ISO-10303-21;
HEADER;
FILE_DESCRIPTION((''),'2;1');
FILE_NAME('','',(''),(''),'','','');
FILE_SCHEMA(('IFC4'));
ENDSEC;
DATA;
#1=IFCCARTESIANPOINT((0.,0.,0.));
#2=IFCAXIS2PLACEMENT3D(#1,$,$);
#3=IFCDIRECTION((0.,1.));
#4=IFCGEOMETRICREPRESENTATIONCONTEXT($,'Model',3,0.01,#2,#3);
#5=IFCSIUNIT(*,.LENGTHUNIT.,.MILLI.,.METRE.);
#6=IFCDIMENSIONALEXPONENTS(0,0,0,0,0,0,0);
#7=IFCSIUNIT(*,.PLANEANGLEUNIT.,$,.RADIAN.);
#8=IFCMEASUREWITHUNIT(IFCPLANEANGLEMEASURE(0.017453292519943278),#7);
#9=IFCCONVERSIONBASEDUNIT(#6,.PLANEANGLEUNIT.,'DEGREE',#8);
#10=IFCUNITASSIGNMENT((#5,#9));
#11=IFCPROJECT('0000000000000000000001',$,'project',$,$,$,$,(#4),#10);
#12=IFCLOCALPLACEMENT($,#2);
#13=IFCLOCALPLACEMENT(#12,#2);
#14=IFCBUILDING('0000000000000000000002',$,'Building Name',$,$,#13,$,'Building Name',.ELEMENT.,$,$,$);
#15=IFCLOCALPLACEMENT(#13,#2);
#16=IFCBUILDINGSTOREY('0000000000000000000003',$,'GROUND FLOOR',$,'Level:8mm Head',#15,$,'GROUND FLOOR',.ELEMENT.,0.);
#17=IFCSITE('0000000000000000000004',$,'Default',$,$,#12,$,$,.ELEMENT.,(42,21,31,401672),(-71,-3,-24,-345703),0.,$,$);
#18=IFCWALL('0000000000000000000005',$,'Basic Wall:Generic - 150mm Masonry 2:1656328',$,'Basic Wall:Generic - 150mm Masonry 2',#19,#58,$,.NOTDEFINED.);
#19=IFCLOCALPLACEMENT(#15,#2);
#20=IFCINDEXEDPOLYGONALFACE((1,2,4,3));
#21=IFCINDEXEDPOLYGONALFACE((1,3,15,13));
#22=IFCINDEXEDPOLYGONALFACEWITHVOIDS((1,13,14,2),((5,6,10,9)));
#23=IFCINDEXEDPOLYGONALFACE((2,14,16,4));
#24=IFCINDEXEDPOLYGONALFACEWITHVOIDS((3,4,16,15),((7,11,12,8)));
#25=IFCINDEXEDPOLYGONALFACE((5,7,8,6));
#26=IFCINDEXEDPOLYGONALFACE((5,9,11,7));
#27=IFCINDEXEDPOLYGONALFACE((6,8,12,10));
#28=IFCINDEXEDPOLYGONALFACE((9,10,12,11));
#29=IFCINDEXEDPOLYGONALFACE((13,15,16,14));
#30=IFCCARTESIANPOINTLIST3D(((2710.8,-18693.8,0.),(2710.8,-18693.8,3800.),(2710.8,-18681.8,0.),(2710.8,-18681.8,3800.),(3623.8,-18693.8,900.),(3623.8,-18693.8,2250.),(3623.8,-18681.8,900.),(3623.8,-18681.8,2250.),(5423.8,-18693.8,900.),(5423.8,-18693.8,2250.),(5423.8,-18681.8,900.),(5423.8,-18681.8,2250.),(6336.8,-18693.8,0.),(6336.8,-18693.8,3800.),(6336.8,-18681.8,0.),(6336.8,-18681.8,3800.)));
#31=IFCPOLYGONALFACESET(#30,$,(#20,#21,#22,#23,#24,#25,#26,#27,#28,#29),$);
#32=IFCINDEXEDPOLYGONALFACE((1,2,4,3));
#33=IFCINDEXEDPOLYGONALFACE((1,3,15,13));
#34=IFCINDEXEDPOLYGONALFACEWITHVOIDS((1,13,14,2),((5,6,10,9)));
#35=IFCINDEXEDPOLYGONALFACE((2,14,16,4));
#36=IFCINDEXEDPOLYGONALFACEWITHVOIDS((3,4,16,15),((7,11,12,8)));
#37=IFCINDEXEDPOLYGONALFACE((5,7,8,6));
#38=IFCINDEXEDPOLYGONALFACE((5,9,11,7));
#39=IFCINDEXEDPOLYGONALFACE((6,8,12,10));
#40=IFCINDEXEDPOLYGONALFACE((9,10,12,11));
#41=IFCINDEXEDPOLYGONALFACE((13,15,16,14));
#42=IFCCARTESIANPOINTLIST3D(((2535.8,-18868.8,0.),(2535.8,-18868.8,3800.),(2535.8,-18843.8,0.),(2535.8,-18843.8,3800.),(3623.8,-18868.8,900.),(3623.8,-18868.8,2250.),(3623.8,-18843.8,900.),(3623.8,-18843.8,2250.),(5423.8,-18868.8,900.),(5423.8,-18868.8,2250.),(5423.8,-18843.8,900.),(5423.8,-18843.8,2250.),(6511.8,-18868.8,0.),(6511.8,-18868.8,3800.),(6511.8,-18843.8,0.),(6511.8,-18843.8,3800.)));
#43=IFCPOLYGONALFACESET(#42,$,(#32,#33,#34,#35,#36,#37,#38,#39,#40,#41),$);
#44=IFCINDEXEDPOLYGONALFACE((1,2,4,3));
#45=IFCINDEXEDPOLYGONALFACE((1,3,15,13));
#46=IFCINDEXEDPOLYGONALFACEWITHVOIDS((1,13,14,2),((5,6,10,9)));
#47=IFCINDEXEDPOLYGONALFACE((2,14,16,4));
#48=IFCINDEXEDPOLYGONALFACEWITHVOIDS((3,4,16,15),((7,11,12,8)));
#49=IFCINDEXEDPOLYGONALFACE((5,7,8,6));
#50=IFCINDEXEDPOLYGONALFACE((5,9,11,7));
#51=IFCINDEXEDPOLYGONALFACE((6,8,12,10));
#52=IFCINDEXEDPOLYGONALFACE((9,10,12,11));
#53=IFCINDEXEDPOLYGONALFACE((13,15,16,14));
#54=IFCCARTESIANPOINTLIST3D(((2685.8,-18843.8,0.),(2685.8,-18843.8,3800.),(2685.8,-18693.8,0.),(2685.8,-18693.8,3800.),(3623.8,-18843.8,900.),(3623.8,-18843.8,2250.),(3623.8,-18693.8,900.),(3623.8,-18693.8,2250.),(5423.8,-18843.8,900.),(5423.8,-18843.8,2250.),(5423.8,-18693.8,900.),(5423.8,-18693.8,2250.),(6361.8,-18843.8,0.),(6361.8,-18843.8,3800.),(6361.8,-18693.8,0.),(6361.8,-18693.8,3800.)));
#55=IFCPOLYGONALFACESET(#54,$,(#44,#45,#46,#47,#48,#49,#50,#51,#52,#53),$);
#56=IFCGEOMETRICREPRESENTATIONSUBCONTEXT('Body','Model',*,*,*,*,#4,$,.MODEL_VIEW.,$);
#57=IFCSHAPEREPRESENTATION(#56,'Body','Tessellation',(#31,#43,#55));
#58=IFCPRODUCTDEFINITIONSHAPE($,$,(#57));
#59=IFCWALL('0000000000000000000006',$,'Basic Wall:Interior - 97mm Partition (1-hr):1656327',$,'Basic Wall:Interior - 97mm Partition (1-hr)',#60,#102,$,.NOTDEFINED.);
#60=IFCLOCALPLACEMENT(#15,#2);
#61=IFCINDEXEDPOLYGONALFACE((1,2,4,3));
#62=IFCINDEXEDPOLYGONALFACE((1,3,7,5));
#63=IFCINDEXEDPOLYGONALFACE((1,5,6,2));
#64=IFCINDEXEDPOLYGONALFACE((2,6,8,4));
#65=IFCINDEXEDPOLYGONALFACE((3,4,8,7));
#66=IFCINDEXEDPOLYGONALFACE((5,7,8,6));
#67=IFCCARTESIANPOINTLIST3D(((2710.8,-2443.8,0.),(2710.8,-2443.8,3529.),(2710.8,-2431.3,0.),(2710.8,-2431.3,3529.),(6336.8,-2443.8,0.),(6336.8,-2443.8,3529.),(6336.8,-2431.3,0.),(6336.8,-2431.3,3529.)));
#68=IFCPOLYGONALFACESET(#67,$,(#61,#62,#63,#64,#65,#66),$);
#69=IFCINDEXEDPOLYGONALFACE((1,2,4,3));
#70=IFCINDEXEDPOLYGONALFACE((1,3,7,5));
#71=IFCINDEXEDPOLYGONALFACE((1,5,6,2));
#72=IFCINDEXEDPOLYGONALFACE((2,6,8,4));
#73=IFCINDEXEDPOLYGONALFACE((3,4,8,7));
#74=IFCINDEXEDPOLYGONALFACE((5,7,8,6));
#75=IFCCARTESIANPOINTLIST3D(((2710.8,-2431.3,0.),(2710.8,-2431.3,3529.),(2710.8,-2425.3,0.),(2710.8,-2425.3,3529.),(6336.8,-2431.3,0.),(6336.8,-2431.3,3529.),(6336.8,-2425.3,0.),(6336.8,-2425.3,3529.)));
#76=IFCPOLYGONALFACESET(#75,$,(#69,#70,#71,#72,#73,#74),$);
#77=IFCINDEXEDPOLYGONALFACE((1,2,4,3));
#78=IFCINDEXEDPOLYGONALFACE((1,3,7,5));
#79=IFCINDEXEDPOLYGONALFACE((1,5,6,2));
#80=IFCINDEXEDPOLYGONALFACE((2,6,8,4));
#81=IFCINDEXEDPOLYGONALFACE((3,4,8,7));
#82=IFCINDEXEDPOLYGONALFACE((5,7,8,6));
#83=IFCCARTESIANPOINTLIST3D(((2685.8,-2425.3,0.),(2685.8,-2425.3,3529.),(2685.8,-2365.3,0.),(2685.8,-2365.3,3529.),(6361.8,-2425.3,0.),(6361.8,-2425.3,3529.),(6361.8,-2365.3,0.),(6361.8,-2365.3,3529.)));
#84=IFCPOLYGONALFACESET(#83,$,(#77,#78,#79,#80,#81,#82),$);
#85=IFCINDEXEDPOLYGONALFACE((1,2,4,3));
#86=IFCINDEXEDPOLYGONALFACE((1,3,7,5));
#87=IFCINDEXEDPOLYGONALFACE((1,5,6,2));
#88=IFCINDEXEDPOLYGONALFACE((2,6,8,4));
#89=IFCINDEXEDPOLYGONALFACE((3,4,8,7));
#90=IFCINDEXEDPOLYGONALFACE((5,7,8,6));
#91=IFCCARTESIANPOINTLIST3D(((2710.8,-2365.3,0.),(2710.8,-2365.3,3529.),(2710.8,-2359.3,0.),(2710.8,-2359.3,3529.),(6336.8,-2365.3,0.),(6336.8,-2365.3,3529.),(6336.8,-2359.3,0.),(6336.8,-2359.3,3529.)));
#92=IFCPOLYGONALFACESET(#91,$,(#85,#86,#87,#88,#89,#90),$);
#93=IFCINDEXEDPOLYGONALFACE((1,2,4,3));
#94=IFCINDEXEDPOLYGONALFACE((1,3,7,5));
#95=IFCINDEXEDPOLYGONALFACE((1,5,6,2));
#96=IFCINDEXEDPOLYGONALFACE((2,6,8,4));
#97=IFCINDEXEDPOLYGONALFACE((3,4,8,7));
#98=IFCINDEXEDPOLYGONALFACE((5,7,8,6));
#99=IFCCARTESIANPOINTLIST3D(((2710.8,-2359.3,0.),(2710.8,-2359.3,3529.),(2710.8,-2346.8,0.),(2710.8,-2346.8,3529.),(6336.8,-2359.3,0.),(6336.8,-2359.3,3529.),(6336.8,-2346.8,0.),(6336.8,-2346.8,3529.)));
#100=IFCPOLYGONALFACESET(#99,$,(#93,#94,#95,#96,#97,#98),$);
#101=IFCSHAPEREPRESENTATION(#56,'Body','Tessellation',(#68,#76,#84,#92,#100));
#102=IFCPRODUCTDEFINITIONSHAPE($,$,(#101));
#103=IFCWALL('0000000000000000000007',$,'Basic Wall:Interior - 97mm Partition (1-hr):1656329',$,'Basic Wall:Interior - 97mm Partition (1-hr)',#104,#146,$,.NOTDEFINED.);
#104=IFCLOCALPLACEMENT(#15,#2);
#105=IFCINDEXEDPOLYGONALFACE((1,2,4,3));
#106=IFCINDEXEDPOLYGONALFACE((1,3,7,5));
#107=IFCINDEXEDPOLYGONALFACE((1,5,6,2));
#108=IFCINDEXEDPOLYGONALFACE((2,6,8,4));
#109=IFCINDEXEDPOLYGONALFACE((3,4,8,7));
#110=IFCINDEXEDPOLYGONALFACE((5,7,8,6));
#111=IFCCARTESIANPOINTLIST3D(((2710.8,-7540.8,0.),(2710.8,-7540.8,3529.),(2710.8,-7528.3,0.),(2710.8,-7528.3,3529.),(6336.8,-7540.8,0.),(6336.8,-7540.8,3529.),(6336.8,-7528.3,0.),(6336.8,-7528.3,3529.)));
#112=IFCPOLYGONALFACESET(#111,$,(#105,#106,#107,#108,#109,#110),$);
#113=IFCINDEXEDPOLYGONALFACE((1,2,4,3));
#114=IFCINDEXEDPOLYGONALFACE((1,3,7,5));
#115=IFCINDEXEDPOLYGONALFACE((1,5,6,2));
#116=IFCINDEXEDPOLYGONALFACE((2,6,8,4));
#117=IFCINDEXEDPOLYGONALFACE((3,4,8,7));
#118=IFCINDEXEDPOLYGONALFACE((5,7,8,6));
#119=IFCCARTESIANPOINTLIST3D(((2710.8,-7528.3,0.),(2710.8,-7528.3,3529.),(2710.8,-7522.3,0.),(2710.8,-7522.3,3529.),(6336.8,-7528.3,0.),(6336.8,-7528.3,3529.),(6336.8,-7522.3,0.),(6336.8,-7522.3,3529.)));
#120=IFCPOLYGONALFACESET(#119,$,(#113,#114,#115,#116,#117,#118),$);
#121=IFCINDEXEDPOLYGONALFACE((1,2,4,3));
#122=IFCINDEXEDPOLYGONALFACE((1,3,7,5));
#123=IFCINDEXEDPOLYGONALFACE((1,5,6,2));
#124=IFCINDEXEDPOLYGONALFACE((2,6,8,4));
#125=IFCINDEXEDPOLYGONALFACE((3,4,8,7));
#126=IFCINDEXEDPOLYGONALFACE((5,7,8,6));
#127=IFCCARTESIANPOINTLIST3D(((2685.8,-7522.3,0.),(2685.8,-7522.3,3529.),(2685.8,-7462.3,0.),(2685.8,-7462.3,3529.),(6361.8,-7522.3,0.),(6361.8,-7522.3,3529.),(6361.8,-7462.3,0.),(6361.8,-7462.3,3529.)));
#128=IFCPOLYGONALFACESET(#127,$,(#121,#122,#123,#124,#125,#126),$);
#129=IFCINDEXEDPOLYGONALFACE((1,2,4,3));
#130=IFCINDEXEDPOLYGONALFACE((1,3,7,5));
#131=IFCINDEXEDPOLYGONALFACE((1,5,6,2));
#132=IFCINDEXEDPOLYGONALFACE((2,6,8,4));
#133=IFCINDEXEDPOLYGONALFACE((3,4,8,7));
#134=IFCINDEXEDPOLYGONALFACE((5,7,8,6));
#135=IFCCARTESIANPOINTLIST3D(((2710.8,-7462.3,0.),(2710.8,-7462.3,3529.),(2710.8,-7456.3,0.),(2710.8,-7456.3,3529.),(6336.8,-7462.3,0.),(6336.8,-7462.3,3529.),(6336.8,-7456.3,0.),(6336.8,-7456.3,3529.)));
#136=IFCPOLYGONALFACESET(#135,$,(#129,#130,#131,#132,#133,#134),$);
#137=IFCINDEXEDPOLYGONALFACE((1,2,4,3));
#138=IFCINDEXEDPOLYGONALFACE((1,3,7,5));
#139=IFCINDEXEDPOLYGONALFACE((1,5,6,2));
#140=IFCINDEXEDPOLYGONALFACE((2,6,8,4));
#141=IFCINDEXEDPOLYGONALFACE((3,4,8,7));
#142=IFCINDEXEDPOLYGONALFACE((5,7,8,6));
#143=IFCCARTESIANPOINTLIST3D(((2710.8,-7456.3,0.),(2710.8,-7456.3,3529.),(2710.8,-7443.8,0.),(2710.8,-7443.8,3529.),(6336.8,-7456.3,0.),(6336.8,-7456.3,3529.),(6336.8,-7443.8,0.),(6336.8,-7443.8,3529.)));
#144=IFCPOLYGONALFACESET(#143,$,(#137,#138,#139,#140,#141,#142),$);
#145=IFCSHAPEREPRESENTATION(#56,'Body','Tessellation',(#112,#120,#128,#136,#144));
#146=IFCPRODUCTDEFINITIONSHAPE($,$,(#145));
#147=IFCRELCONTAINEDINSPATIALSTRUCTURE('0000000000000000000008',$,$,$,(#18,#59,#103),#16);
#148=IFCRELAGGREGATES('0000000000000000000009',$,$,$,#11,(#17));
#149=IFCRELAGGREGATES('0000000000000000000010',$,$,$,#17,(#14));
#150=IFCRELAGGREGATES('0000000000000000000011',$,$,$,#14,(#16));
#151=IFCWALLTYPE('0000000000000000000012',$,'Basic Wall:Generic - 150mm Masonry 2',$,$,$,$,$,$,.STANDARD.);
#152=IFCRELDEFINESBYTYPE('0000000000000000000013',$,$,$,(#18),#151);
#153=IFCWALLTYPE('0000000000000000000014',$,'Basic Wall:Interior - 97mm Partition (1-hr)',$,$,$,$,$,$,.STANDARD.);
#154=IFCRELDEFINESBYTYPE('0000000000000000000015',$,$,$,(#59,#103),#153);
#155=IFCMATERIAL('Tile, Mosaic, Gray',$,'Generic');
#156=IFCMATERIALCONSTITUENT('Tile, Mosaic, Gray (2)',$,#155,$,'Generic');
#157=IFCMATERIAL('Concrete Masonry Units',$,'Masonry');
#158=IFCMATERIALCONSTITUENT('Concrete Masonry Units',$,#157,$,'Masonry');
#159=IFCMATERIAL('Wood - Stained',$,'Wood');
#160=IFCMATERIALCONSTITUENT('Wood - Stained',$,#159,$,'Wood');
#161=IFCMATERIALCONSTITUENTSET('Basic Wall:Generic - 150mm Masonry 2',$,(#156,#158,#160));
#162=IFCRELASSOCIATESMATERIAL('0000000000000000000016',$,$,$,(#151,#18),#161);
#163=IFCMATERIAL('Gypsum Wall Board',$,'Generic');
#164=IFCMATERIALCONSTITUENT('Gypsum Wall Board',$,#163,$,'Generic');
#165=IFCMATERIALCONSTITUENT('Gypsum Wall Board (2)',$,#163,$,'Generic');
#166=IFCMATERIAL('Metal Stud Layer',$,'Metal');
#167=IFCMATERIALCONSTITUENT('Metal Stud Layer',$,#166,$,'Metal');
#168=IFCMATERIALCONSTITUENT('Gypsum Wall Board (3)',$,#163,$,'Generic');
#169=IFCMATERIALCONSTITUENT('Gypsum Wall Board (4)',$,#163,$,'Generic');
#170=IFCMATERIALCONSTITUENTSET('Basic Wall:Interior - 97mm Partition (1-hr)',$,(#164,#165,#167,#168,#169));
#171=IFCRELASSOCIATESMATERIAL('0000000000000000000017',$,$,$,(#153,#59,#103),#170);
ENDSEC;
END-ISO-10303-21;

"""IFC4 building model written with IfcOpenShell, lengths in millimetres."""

from ifc_helpers import new_model, entity, si_unit, converted_unit, direction, frame, origin, place, context, subcontext, project, spatial, indexed_curve, outline, extrude, material, constituent, constituent_set, type_object, element, save


model = new_model("IFC4")

# Units and contexts
model_context = context("Model", 3, precision=0.01, world=origin(), true_north=direction((0.0, 1.0)))
body_context = subcontext(model_context, "Body", "Model", "MODEL_VIEW")
ifc_project = project(units=[si_unit("LENGTHUNIT", "METRE", prefix="MILLI"), converted_unit("PLANEANGLEUNIT", "DEGREE", entity("IfcPlaneAngleMeasure", 0.017453292519943278), si_unit("PLANEANGLEUNIT", "RADIAN"), dimensions=[0, 0, 0, 0, 0, 0, 0])], contexts=[model_context])

# Site, building, storey
site_placement = place(None, origin())
site = spatial("IfcSite", under=ifc_project, at=site_placement, Name="Default", CompositionType="ELEMENT", RefLatitude=(42, 21, 31, 401672), RefLongitude=(-71, -3, -24, -345703), RefElevation=0.0)
building_placement = place(site_placement, origin())
building = spatial("IfcBuilding", under=site, at=building_placement, Name="Building Name", LongName="Building Name", CompositionType="ELEMENT")
storey_placement = place(building_placement, origin())
storey = spatial("IfcBuildingStorey", under=building, at=storey_placement, Name="GROUND FLOOR", ObjectType="Level:8mm Head", LongName="GROUND FLOOR", CompositionType="ELEMENT", Elevation=0.0)

# Shared definitions
ifc_material_1 = material(Name="Tile, Mosaic, Gray", Category="Generic")
ifc_constituent_1 = constituent(ifc_material_1, Name="Tile, Mosaic, Gray (2)", Category="Generic")
ifc_material_2 = material(Name="Concrete Masonry Units", Category="Masonry")
ifc_constituent_2 = constituent(ifc_material_2, Name="Concrete Masonry Units", Category="Masonry")
ifc_material_3 = material(Name="Wood - Stained", Category="Wood")
ifc_constituent_3 = constituent(ifc_material_3, Name="Wood - Stained", Category="Wood")
ifc_constituent_set_1 = constituent_set(constituents=[ifc_constituent_1, ifc_constituent_2, ifc_constituent_3], Name="Basic Wall:Generic - 150mm Masonry 2")
wall_type_1 = type_object("IfcWallType", Name="Basic Wall:Generic - 150mm Masonry 2", PredefinedType="STANDARD", material=ifc_constituent_set_1)

# Wall, opening
wall_1_placement = place(storey_placement, frame((2710.8, -18775.3, 0.0)))
wall_1 = element("IfcWall", 1, at=wall_1_placement, inside=storey, type_object=wall_type_1, material=ifc_constituent_set_1, Name="Basic Wall:Generic - 150mm Masonry 2:1656328", ObjectType="Basic Wall:Generic - 150mm Masonry 2", PredefinedType="NOTDEFINED", context=body_context, shape_type="SweptSolid", body=[
    extrude(outline(indexed_curve([(-1900.0, -1813.0), (1900.0, -1813.0), (1900.0, 1813.0), (-1900.0, 1813.0), (-1900.0, -1813.0)], self_intersect=False), holes=[indexed_curve([(350.0, 900.0), (350.0, -900.0), (-1000.0, -900.0), (-1000.0, 900.0), (350.0, 900.0)], self_intersect=False)]), frame((1813.0, 81.5, 1900.0), z_axis=(0.0, 1.0, 0.0), x_axis=(0.0, 0.0, 1.0)), (0.0, 0.0, 1.0), 12.0),
    extrude(outline(indexed_curve([(-1900.0, -1988.0), (1900.0, -1988.0), (1900.0, 1988.0), (-1900.0, 1988.0), (-1900.0, -1988.0)], self_intersect=False), holes=[indexed_curve([(350.0, 900.0), (350.0, -900.0), (-1000.0, -900.0), (-1000.0, 900.0), (350.0, 900.0)], self_intersect=False)]), frame((1813.0, -93.5, 1900.0), z_axis=(0.0, 1.0, 0.0), x_axis=(0.0, 0.0, 1.0)), (0.0, 0.0, 1.0), 25.0),
    extrude(outline(indexed_curve([(-1900.0, -1838.0), (1900.0, -1838.0), (1900.0, 1838.0), (-1900.0, 1838.0), (-1900.0, -1838.0)], self_intersect=False), holes=[indexed_curve([(350.0, 900.0), (350.0, -900.0), (-1000.0, -900.0), (-1000.0, 900.0), (350.0, 900.0)], self_intersect=False)]), frame((1813.0, -68.5, 1900.0), z_axis=(0.0, 1.0, 0.0), x_axis=(0.0, 0.0, 1.0)), (0.0, 0.0, 1.0), 150.0),
])
opening_1_placement = place(wall_1_placement, frame((2713.0, 93.5, 900.0)))
element("IfcOpeningElement", 2, at=opening_1_placement, cuts=wall_1, PredefinedType="OPENING", context=body_context, shape_type="SweptSolid", body=[
    extrude(outline(indexed_curve([(1350.0, 0.0), (1350.0, 1800.0), (0.0, 1800.0), (0.0, 0.0), (1350.0, 0.0)], self_intersect=False)), frame((0.0, 0.0, 0.0), z_axis=(0.0, -1.0, 0.0), x_axis=(0.0, 0.0, 1.0)), (0.0, 0.0, 1.0), 187.0),
])

# Walls
ifc_material_4 = material(Name="Gypsum Wall Board", Category="Generic")
ifc_constituent_4 = constituent(ifc_material_4, Name="Gypsum Wall Board", Category="Generic")
ifc_constituent_5 = constituent(ifc_material_4, Name="Gypsum Wall Board (2)", Category="Generic")
ifc_material_5 = material(Name="Metal Stud Layer", Category="Metal")
ifc_constituent_6 = constituent(ifc_material_5, Name="Metal Stud Layer", Category="Metal")
ifc_constituent_7 = constituent(ifc_material_4, Name="Gypsum Wall Board (3)", Category="Generic")
ifc_constituent_8 = constituent(ifc_material_4, Name="Gypsum Wall Board (4)", Category="Generic")
ifc_constituent_set_2 = constituent_set(constituents=[ifc_constituent_4, ifc_constituent_5, ifc_constituent_6, ifc_constituent_7, ifc_constituent_8], Name="Basic Wall:Interior - 97mm Partition (1-hr)")
wall_type_2 = type_object("IfcWallType", Name="Basic Wall:Interior - 97mm Partition (1-hr)", PredefinedType="STANDARD", material=ifc_constituent_set_2)
wall_2_placement = place(storey_placement, frame((6336.8, -2395.3, 0.0), z_axis=(0.0, 0.0, 1.0), x_axis=(-1.0, 0.0, 0.0)))
element("IfcWall", 3, at=wall_2_placement, inside=storey, type_object=wall_type_2, material=ifc_constituent_set_2, Name="Basic Wall:Interior - 97mm Partition (1-hr):1656327", ObjectType="Basic Wall:Interior - 97mm Partition (1-hr)", PredefinedType="NOTDEFINED", context=body_context, shape_type="SweptSolid", body=[
    extrude(outline(indexed_curve([(-6.2, -1764.5), (6.3, -1764.5), (6.2, 1764.5), (-6.2, 1764.5), (-6.2, -1764.5)], self_intersect=False)), frame((3626.0, 42.3, 1764.5), z_axis=(-1.0, 0.0, 0.0), x_axis=(0.0, -1.0, 0.0)), (0.0, 0.0, 1.0), 3626.0),
    extrude(outline(indexed_curve([(-1764.5, -3.0), (1764.5, -3.0), (1764.5, 3.0), (-1764.5, 3.0), (-1764.5, -3.0)], self_intersect=False)), frame((3626.0, 33.0, 1764.5), z_axis=(-1.0, 0.0, 0.0), x_axis=(0.0, 0.0, 1.0)), (0.0, 0.0, 1.0), 3626.0),
    extrude(outline(indexed_curve([(-1764.5, -30.0), (1764.5, -30.0), (1764.5, 30.0), (-1764.5, 30.0), (-1764.5, -30.0)], self_intersect=False)), frame((3651.0, 0.0, 1764.5), z_axis=(-1.0, 0.0, 0.0), x_axis=(0.0, 0.0, 1.0)), (0.0, 0.0, 1.0), 3676.0),
    extrude(outline(indexed_curve([(-1764.5, -3.0), (1764.5, -3.0), (1764.5, 3.0), (-1764.5, 3.0), (-1764.5, -3.0)], self_intersect=False)), frame((3626.0, -33.0, 1764.5), z_axis=(-1.0, 0.0, 0.0), x_axis=(0.0, 0.0, 1.0)), (0.0, 0.0, 1.0), 3626.0),
    extrude(outline(indexed_curve([(-6.3, -1764.5), (6.3, -1764.5), (6.3, 1764.5), (-6.3, 1764.5), (-6.3, -1764.5)], self_intersect=False)), frame((3626.0, -42.3, 1764.5), z_axis=(-1.0, 0.0, 0.0), x_axis=(0.0, 1.0, 0.0)), (0.0, 0.0, 1.0), 3626.0),
])
wall_3_placement = place(storey_placement, frame((6336.8, -7492.3, 0.0), z_axis=(0.0, 0.0, 1.0), x_axis=(-1.0, 0.0, 0.0)))
element("IfcWall", 4, at=wall_3_placement, inside=storey, type_object=wall_type_2, material=ifc_constituent_set_2, Name="Basic Wall:Interior - 97mm Partition (1-hr):1656329", ObjectType="Basic Wall:Interior - 97mm Partition (1-hr)", PredefinedType="NOTDEFINED", context=body_context, shape_type="SweptSolid", body=[
    extrude(outline(indexed_curve([(-6.2, -1764.5), (6.2, -1764.5), (6.3, 1764.5), (-6.2, 1764.5), (-6.2, -1764.5)], self_intersect=False)), frame((3626.0, 42.3, 1764.5), z_axis=(-1.0, 0.0, 0.0), x_axis=(0.0, -1.0, 0.0)), (0.0, 0.0, 1.0), 3626.0),
    extrude(outline(indexed_curve([(-1764.5, -3.0), (1764.5, -3.0), (1764.5, 3.0), (-1764.5, 3.0), (-1764.5, -3.0)], self_intersect=False)), frame((3626.0, 33.0, 1764.5), z_axis=(-1.0, 0.0, 0.0), x_axis=(0.0, 0.0, 1.0)), (0.0, 0.0, 1.0), 3626.0),
    extrude(outline(indexed_curve([(-1764.5, -30.0), (1764.5, -30.0), (1764.5, 30.0), (-1764.5, 30.0), (-1764.5, -30.0)], self_intersect=False)), frame((3651.0, 0.0, 1764.5), z_axis=(-1.0, 0.0, 0.0), x_axis=(0.0, 0.0, 1.0)), (0.0, 0.0, 1.0), 3676.0),
    extrude(outline(indexed_curve([(-1764.5, -3.0), (1764.5, -3.0), (1764.5, 3.0), (-1764.5, 3.0), (-1764.5, -3.0)], self_intersect=False)), frame((3626.0, -33.0, 1764.5), z_axis=(-1.0, 0.0, 0.0), x_axis=(0.0, 0.0, 1.0)), (0.0, 0.0, 1.0), 3626.0),
    extrude(outline(indexed_curve([(-6.2, -1764.5), (6.3, -1764.5), (6.2, 1764.5), (-6.3, 1764.5), (-6.2, -1764.5)], self_intersect=False)), frame((3626.0, -42.3, 1764.5), z_axis=(-1.0, 0.0, 0.0), x_axis=(0.0, 1.0, 0.0)), (0.0, 0.0, 1.0), 3626.0),
])

save(model, "model.ifc")
